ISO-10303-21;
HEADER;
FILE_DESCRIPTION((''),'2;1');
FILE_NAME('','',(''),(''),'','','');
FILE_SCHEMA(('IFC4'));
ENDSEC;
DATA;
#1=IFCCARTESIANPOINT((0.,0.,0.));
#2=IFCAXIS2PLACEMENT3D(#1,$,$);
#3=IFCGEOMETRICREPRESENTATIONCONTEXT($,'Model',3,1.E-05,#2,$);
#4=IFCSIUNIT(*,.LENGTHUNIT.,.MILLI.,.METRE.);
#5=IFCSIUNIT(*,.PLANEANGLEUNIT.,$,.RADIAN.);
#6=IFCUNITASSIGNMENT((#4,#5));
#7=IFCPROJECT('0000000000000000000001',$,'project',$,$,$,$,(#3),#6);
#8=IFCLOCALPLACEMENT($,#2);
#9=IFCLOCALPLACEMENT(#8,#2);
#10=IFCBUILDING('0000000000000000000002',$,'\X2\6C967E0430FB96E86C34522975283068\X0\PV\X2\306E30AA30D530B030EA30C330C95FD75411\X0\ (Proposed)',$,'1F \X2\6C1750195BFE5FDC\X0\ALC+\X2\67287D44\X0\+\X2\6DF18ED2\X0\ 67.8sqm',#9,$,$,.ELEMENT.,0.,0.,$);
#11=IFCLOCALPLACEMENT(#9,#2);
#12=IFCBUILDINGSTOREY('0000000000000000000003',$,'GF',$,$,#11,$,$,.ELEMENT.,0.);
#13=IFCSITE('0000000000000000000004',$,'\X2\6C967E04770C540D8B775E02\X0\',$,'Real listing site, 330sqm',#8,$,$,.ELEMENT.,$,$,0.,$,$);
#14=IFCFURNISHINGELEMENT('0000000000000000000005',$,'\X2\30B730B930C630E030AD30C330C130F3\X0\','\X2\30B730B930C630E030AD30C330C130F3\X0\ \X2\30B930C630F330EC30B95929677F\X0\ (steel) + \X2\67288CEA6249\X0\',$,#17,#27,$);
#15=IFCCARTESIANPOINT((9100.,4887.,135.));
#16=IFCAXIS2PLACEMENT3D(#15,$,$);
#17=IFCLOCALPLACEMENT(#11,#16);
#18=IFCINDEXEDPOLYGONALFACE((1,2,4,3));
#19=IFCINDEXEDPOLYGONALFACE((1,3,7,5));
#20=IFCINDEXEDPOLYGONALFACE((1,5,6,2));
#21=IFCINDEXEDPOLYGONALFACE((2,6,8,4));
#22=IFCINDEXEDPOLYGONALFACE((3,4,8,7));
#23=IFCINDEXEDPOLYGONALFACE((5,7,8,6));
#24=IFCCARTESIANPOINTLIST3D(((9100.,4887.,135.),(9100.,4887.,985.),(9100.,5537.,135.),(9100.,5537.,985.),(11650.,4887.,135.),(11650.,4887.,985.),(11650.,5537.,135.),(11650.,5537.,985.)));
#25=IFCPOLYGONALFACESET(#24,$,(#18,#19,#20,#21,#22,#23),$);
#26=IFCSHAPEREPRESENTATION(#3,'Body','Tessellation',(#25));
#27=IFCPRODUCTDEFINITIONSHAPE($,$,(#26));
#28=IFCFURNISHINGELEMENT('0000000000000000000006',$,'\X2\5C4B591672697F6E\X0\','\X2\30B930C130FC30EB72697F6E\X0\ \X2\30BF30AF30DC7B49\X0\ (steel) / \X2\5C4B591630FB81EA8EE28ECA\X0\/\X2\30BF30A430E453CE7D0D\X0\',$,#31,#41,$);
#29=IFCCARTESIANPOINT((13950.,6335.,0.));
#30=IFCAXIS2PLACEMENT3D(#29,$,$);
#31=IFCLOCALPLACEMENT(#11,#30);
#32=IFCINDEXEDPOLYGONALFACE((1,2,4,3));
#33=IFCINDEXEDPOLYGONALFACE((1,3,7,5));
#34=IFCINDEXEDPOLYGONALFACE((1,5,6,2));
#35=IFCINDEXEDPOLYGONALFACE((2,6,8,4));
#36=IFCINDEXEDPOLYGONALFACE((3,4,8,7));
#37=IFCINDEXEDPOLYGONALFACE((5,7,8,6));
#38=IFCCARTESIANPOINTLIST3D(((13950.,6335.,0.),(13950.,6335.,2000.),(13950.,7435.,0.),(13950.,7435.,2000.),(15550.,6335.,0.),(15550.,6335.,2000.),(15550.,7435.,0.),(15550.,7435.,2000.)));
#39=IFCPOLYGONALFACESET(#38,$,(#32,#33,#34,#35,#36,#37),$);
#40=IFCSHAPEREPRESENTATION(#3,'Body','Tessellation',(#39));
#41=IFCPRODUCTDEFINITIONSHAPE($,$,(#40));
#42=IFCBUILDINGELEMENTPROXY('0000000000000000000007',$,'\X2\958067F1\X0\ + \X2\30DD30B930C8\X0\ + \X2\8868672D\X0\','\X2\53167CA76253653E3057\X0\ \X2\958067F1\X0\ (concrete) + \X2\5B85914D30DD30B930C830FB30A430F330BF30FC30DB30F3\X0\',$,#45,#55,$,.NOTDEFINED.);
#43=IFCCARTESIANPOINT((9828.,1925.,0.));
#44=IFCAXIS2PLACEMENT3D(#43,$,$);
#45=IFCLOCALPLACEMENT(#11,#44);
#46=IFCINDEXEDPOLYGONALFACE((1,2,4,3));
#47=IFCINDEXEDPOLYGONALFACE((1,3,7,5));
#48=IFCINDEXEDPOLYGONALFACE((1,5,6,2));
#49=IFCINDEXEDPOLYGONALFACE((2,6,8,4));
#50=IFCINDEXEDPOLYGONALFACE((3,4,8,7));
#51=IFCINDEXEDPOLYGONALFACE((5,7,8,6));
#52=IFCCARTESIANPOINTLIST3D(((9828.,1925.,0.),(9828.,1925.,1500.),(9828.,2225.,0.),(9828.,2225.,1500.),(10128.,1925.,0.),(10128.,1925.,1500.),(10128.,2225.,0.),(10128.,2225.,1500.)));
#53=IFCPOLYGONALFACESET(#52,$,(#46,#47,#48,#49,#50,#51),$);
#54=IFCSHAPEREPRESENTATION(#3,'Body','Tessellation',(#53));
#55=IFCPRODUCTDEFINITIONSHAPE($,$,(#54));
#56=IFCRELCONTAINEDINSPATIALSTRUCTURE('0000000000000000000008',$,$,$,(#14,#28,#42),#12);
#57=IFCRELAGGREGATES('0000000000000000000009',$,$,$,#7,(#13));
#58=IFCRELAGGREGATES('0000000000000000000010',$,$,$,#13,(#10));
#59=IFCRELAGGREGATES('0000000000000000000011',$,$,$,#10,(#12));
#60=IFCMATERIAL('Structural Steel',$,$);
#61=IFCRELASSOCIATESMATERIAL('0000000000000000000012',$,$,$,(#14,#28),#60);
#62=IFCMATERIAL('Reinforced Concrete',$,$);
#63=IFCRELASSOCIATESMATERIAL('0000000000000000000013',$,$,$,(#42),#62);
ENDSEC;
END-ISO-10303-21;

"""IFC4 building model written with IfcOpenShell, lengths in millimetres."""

from ifc_helpers import new_model, si_unit, frame, frame_2d, origin, place, context, project, spatial, rectangle, extrude, material, element, save


model = new_model("IFC4")

# Units and contexts
model_context = context("Model", 3, precision=1e-05, world=origin())
ifc_project = project(units=[si_unit("LENGTHUNIT", "METRE", prefix="MILLI"), si_unit("PLANEANGLEUNIT", "RADIAN")], contexts=[model_context])

# Site, building, storey
site_placement = place(None, origin())
site = spatial("IfcSite", under=ifc_project, at=site_placement, Name="沖縄県名護市", ObjectType="Real listing site, 330sqm", CompositionType="ELEMENT", RefElevation=0.0)
building_placement = place(site_placement, origin())
building = spatial("IfcBuilding", under=site, at=building_placement, Name="沖縄・雨水利用とPVのオフグリッド志向 (Proposed)", ObjectType="1F 気候対応ALC+木組+深軒 67.8sqm", CompositionType="ELEMENT", ElevationOfRefHeight=0.0, ElevationOfTerrain=0.0)
storey_placement = place(building_placement, origin())
storey = spatial("IfcBuildingStorey", under=building, at=storey_placement, Name="GF", CompositionType="ELEMENT", Elevation=0.0)

# Shared definitions
ifc_material_1 = material(Name="Reinforced Concrete")

# Shared definitions
ifc_material_2 = material(Name="Structural Steel")

# Furnishing elements
furnishing_1_placement = place(storey_placement, frame((9100.0, 4887.0, 135.0)))
element("IfcFurnishingElement", 1, at=furnishing_1_placement, inside=storey, material=ifc_material_2, Name="システムキッチン", Description="システムキッチン ステンレス天板 (steel) + 木質扉", context=model_context, shape_type="SweptSolid", body=[
    extrude(rectangle(XDim=2550.0, YDim=650.0, at=frame_2d((1275.0, 325.0))), frame((9100.0, 4887.0, 135.0)), (0.0, 0.0, 1.0), 850.0),
])
furnishing_2_placement = place(storey_placement, frame((13950.0, 6335.0, 0.0)))
element("IfcFurnishingElement", 2, at=furnishing_2_placement, inside=storey, material=ifc_material_2, Name="屋外物置", Description="スチール物置 タクボ等 (steel) / 屋外・自転車/タイヤ収納", context=model_context, shape_type="SweptSolid", body=[
    extrude(rectangle(XDim=1600.0, YDim=1100.0, at=frame_2d((800.0, 550.0))), frame((13950.0, 6335.0, 0.0)), (0.0, 0.0, 1.0), 2000.0),
])

# Building element proxy
proxy_placement = place(storey_placement, frame((9828.0, 1925.0, 0.0)))
element("IfcBuildingElementProxy", 3, at=proxy_placement, inside=storey, material=ifc_material_1, Name="門柱 + ポスト + 表札", Description="化粧打放し 門柱 (concrete) + 宅配ポスト・インターホン", PredefinedType="NOTDEFINED", context=model_context, shape_type="SweptSolid", body=[
    extrude(rectangle(XDim=300.0, YDim=300.0, at=frame_2d((150.0, 150.0))), frame((9828.0, 1925.0, 0.0)), (0.0, 0.0, 1.0), 1500.0),
])

save(model, "model.ifc")
